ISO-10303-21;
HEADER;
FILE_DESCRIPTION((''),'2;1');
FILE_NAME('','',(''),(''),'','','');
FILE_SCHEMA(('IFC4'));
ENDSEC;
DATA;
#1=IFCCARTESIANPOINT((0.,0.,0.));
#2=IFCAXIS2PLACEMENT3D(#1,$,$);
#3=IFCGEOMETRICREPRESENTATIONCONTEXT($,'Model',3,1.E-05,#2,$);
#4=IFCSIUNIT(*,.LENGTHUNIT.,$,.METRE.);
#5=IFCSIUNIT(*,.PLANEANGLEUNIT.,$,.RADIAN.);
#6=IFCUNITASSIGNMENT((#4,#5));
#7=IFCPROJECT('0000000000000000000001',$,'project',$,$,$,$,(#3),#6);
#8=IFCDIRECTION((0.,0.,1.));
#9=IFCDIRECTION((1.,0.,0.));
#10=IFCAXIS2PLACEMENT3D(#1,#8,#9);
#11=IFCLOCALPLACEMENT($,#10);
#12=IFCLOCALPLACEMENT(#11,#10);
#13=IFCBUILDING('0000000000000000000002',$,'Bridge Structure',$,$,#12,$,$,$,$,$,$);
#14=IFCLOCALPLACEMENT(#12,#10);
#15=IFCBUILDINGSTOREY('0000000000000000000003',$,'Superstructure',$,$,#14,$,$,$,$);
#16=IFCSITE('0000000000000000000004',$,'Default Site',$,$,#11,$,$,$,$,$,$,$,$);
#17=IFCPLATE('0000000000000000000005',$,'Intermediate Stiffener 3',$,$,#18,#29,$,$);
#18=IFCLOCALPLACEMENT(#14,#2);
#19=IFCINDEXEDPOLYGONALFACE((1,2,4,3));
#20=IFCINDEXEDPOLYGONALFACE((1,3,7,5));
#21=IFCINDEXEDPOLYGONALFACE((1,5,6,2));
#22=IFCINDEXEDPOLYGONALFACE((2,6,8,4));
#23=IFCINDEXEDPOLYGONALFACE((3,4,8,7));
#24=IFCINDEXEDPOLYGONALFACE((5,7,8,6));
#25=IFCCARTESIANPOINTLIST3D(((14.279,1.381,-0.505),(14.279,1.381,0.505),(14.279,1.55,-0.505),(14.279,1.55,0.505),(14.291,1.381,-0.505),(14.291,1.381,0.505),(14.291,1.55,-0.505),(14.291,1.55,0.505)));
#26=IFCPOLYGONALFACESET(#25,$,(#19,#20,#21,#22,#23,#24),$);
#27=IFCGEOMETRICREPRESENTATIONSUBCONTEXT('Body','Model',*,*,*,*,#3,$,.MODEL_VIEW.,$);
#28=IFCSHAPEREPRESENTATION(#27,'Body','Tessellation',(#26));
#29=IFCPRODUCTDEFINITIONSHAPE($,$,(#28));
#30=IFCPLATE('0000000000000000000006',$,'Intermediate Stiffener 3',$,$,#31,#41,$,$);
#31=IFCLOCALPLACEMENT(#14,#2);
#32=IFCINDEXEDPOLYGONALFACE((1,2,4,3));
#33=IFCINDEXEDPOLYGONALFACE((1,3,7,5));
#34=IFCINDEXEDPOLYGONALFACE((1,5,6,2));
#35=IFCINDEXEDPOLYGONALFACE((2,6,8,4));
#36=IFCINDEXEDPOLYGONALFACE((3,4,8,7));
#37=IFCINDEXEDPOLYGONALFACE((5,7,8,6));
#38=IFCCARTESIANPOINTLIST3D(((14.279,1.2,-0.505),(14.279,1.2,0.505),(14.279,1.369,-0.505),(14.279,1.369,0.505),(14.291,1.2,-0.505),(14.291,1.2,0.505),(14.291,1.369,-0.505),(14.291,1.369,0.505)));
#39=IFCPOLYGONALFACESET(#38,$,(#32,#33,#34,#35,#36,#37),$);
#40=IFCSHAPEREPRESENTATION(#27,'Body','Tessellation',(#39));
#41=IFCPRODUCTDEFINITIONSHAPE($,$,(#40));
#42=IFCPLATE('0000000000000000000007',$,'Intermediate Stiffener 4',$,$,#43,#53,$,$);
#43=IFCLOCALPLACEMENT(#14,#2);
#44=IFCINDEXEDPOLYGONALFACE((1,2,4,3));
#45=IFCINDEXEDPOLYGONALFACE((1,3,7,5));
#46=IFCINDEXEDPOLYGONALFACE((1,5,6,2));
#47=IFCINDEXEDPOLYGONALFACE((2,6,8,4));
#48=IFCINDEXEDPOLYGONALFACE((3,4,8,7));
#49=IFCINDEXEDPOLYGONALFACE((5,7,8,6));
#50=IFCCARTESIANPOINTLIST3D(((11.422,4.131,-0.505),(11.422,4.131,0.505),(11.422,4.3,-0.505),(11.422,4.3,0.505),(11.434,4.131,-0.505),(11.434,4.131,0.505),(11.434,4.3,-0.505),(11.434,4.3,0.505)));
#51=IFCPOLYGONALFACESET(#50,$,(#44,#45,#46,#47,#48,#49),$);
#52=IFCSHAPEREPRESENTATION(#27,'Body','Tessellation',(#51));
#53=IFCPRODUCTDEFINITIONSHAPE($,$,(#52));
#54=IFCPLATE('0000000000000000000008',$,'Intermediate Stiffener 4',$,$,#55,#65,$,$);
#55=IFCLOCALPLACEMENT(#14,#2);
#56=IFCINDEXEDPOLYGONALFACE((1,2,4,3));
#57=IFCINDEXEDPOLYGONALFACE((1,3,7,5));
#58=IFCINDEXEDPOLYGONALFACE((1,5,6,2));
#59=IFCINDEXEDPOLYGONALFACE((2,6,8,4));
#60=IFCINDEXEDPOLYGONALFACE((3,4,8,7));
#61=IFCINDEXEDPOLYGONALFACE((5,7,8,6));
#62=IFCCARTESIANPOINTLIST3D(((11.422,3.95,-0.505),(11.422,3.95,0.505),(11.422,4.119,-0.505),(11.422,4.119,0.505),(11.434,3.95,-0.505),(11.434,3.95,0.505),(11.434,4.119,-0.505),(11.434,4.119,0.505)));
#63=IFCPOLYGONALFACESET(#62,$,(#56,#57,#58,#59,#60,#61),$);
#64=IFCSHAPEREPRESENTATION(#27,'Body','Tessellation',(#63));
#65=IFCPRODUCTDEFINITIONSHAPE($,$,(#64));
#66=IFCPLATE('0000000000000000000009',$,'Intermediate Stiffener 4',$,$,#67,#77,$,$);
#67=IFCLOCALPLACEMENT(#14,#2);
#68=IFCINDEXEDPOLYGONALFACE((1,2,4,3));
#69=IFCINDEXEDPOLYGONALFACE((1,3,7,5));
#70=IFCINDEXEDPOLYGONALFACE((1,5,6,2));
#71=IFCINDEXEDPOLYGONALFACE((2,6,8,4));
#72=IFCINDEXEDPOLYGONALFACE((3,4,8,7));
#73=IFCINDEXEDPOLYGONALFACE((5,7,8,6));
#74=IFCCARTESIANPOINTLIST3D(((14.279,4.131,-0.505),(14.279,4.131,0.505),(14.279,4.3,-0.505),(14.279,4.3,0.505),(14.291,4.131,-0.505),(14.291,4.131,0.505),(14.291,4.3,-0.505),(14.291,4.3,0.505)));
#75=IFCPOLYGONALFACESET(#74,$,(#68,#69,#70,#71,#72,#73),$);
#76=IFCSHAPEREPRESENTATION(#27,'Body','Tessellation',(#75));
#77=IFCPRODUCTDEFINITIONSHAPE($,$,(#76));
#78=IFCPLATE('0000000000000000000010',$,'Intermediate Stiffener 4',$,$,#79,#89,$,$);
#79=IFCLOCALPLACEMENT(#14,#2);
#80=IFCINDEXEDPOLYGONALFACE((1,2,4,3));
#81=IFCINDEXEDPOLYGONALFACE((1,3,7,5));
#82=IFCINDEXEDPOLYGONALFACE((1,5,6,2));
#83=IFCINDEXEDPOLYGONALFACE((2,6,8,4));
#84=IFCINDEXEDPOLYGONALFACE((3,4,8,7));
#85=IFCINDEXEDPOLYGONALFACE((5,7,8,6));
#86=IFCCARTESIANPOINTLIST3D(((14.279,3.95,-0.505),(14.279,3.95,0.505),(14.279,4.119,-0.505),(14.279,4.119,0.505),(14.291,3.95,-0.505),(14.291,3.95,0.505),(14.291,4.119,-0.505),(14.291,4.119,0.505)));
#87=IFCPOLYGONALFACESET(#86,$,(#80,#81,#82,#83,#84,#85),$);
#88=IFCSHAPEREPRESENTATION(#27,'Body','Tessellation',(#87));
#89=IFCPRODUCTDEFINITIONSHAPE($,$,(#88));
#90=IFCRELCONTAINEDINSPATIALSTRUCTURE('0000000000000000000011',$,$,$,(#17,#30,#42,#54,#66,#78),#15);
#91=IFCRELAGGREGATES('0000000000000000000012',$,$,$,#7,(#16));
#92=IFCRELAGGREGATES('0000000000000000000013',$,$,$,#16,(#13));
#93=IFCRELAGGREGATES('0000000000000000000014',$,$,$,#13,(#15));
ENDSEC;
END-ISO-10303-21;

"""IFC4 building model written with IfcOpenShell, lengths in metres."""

from ifc_helpers import new_model, si_unit, frame, origin, origin_with_axes, origin_2d_with_axis, place, context, subcontext, project, spatial, rectangle, extrude, element, save


model = new_model("IFC4")

# Units and contexts
model_context = context("Model", 3, precision=1e-05, world=origin())
body_context = subcontext(model_context, "Body", "Model", "MODEL_VIEW")
ifc_project = project(units=[si_unit("LENGTHUNIT", "METRE"), si_unit("PLANEANGLEUNIT", "RADIAN")], contexts=[model_context])

# Site, building, storey
site_placement = place(None, origin_with_axes())
site = spatial("IfcSite", under=ifc_project, at=site_placement, Name="Default Site")
building_placement = place(site_placement, origin_with_axes())
building = spatial("IfcBuilding", under=site, at=building_placement, Name="Bridge Structure")
storey_placement = place(building_placement, origin_with_axes())
storey = spatial("IfcBuildingStorey", under=building, at=storey_placement, Name="Superstructure")

# Plates
for number, where, z_axis, x_axis, name in (
    (1, (14.285, 1.4655, -0.505), (0.0, 0.0, 1.0), (1.0, 0.0, 0.0), "Intermediate Stiffener 3"),
    (2, (14.285, 1.2845, -0.505), (0.0, 0.0, 1.0), (1.0, 0.0, 0.0), "Intermediate Stiffener 3"),
    (3, (11.428, 4.2155, -0.505), (0.0, 0.0, 1.0), (1.0, 0.0, 0.0), "Intermediate Stiffener 4"),
    (4, (11.428, 4.0345, -0.505), (0.0, 0.0, 1.0), (1.0, 0.0, 0.0), "Intermediate Stiffener 4"),
    (5, (14.285, 4.2155, -0.505), (0.0, 0.0, 1.0), (1.0, 0.0, 0.0), "Intermediate Stiffener 4"),
    (6, (14.285, 4.0345, -0.505), (0.0, 0.0, 1.0), (1.0, 0.0, 0.0), "Intermediate Stiffener 4"),
):
    element("IfcPlate", number, at=place(storey_placement, frame(where, z_axis=z_axis, x_axis=x_axis)), inside=storey, Name=name, context=body_context, shape_type="SweptSolid", body=[
        extrude(rectangle(XDim=0.012, YDim=0.169, at=origin_2d_with_axis()), origin_with_axes(), (0.0, 0.0, 1.0), 1.01),
    ])

save(model, "model.ifc")
